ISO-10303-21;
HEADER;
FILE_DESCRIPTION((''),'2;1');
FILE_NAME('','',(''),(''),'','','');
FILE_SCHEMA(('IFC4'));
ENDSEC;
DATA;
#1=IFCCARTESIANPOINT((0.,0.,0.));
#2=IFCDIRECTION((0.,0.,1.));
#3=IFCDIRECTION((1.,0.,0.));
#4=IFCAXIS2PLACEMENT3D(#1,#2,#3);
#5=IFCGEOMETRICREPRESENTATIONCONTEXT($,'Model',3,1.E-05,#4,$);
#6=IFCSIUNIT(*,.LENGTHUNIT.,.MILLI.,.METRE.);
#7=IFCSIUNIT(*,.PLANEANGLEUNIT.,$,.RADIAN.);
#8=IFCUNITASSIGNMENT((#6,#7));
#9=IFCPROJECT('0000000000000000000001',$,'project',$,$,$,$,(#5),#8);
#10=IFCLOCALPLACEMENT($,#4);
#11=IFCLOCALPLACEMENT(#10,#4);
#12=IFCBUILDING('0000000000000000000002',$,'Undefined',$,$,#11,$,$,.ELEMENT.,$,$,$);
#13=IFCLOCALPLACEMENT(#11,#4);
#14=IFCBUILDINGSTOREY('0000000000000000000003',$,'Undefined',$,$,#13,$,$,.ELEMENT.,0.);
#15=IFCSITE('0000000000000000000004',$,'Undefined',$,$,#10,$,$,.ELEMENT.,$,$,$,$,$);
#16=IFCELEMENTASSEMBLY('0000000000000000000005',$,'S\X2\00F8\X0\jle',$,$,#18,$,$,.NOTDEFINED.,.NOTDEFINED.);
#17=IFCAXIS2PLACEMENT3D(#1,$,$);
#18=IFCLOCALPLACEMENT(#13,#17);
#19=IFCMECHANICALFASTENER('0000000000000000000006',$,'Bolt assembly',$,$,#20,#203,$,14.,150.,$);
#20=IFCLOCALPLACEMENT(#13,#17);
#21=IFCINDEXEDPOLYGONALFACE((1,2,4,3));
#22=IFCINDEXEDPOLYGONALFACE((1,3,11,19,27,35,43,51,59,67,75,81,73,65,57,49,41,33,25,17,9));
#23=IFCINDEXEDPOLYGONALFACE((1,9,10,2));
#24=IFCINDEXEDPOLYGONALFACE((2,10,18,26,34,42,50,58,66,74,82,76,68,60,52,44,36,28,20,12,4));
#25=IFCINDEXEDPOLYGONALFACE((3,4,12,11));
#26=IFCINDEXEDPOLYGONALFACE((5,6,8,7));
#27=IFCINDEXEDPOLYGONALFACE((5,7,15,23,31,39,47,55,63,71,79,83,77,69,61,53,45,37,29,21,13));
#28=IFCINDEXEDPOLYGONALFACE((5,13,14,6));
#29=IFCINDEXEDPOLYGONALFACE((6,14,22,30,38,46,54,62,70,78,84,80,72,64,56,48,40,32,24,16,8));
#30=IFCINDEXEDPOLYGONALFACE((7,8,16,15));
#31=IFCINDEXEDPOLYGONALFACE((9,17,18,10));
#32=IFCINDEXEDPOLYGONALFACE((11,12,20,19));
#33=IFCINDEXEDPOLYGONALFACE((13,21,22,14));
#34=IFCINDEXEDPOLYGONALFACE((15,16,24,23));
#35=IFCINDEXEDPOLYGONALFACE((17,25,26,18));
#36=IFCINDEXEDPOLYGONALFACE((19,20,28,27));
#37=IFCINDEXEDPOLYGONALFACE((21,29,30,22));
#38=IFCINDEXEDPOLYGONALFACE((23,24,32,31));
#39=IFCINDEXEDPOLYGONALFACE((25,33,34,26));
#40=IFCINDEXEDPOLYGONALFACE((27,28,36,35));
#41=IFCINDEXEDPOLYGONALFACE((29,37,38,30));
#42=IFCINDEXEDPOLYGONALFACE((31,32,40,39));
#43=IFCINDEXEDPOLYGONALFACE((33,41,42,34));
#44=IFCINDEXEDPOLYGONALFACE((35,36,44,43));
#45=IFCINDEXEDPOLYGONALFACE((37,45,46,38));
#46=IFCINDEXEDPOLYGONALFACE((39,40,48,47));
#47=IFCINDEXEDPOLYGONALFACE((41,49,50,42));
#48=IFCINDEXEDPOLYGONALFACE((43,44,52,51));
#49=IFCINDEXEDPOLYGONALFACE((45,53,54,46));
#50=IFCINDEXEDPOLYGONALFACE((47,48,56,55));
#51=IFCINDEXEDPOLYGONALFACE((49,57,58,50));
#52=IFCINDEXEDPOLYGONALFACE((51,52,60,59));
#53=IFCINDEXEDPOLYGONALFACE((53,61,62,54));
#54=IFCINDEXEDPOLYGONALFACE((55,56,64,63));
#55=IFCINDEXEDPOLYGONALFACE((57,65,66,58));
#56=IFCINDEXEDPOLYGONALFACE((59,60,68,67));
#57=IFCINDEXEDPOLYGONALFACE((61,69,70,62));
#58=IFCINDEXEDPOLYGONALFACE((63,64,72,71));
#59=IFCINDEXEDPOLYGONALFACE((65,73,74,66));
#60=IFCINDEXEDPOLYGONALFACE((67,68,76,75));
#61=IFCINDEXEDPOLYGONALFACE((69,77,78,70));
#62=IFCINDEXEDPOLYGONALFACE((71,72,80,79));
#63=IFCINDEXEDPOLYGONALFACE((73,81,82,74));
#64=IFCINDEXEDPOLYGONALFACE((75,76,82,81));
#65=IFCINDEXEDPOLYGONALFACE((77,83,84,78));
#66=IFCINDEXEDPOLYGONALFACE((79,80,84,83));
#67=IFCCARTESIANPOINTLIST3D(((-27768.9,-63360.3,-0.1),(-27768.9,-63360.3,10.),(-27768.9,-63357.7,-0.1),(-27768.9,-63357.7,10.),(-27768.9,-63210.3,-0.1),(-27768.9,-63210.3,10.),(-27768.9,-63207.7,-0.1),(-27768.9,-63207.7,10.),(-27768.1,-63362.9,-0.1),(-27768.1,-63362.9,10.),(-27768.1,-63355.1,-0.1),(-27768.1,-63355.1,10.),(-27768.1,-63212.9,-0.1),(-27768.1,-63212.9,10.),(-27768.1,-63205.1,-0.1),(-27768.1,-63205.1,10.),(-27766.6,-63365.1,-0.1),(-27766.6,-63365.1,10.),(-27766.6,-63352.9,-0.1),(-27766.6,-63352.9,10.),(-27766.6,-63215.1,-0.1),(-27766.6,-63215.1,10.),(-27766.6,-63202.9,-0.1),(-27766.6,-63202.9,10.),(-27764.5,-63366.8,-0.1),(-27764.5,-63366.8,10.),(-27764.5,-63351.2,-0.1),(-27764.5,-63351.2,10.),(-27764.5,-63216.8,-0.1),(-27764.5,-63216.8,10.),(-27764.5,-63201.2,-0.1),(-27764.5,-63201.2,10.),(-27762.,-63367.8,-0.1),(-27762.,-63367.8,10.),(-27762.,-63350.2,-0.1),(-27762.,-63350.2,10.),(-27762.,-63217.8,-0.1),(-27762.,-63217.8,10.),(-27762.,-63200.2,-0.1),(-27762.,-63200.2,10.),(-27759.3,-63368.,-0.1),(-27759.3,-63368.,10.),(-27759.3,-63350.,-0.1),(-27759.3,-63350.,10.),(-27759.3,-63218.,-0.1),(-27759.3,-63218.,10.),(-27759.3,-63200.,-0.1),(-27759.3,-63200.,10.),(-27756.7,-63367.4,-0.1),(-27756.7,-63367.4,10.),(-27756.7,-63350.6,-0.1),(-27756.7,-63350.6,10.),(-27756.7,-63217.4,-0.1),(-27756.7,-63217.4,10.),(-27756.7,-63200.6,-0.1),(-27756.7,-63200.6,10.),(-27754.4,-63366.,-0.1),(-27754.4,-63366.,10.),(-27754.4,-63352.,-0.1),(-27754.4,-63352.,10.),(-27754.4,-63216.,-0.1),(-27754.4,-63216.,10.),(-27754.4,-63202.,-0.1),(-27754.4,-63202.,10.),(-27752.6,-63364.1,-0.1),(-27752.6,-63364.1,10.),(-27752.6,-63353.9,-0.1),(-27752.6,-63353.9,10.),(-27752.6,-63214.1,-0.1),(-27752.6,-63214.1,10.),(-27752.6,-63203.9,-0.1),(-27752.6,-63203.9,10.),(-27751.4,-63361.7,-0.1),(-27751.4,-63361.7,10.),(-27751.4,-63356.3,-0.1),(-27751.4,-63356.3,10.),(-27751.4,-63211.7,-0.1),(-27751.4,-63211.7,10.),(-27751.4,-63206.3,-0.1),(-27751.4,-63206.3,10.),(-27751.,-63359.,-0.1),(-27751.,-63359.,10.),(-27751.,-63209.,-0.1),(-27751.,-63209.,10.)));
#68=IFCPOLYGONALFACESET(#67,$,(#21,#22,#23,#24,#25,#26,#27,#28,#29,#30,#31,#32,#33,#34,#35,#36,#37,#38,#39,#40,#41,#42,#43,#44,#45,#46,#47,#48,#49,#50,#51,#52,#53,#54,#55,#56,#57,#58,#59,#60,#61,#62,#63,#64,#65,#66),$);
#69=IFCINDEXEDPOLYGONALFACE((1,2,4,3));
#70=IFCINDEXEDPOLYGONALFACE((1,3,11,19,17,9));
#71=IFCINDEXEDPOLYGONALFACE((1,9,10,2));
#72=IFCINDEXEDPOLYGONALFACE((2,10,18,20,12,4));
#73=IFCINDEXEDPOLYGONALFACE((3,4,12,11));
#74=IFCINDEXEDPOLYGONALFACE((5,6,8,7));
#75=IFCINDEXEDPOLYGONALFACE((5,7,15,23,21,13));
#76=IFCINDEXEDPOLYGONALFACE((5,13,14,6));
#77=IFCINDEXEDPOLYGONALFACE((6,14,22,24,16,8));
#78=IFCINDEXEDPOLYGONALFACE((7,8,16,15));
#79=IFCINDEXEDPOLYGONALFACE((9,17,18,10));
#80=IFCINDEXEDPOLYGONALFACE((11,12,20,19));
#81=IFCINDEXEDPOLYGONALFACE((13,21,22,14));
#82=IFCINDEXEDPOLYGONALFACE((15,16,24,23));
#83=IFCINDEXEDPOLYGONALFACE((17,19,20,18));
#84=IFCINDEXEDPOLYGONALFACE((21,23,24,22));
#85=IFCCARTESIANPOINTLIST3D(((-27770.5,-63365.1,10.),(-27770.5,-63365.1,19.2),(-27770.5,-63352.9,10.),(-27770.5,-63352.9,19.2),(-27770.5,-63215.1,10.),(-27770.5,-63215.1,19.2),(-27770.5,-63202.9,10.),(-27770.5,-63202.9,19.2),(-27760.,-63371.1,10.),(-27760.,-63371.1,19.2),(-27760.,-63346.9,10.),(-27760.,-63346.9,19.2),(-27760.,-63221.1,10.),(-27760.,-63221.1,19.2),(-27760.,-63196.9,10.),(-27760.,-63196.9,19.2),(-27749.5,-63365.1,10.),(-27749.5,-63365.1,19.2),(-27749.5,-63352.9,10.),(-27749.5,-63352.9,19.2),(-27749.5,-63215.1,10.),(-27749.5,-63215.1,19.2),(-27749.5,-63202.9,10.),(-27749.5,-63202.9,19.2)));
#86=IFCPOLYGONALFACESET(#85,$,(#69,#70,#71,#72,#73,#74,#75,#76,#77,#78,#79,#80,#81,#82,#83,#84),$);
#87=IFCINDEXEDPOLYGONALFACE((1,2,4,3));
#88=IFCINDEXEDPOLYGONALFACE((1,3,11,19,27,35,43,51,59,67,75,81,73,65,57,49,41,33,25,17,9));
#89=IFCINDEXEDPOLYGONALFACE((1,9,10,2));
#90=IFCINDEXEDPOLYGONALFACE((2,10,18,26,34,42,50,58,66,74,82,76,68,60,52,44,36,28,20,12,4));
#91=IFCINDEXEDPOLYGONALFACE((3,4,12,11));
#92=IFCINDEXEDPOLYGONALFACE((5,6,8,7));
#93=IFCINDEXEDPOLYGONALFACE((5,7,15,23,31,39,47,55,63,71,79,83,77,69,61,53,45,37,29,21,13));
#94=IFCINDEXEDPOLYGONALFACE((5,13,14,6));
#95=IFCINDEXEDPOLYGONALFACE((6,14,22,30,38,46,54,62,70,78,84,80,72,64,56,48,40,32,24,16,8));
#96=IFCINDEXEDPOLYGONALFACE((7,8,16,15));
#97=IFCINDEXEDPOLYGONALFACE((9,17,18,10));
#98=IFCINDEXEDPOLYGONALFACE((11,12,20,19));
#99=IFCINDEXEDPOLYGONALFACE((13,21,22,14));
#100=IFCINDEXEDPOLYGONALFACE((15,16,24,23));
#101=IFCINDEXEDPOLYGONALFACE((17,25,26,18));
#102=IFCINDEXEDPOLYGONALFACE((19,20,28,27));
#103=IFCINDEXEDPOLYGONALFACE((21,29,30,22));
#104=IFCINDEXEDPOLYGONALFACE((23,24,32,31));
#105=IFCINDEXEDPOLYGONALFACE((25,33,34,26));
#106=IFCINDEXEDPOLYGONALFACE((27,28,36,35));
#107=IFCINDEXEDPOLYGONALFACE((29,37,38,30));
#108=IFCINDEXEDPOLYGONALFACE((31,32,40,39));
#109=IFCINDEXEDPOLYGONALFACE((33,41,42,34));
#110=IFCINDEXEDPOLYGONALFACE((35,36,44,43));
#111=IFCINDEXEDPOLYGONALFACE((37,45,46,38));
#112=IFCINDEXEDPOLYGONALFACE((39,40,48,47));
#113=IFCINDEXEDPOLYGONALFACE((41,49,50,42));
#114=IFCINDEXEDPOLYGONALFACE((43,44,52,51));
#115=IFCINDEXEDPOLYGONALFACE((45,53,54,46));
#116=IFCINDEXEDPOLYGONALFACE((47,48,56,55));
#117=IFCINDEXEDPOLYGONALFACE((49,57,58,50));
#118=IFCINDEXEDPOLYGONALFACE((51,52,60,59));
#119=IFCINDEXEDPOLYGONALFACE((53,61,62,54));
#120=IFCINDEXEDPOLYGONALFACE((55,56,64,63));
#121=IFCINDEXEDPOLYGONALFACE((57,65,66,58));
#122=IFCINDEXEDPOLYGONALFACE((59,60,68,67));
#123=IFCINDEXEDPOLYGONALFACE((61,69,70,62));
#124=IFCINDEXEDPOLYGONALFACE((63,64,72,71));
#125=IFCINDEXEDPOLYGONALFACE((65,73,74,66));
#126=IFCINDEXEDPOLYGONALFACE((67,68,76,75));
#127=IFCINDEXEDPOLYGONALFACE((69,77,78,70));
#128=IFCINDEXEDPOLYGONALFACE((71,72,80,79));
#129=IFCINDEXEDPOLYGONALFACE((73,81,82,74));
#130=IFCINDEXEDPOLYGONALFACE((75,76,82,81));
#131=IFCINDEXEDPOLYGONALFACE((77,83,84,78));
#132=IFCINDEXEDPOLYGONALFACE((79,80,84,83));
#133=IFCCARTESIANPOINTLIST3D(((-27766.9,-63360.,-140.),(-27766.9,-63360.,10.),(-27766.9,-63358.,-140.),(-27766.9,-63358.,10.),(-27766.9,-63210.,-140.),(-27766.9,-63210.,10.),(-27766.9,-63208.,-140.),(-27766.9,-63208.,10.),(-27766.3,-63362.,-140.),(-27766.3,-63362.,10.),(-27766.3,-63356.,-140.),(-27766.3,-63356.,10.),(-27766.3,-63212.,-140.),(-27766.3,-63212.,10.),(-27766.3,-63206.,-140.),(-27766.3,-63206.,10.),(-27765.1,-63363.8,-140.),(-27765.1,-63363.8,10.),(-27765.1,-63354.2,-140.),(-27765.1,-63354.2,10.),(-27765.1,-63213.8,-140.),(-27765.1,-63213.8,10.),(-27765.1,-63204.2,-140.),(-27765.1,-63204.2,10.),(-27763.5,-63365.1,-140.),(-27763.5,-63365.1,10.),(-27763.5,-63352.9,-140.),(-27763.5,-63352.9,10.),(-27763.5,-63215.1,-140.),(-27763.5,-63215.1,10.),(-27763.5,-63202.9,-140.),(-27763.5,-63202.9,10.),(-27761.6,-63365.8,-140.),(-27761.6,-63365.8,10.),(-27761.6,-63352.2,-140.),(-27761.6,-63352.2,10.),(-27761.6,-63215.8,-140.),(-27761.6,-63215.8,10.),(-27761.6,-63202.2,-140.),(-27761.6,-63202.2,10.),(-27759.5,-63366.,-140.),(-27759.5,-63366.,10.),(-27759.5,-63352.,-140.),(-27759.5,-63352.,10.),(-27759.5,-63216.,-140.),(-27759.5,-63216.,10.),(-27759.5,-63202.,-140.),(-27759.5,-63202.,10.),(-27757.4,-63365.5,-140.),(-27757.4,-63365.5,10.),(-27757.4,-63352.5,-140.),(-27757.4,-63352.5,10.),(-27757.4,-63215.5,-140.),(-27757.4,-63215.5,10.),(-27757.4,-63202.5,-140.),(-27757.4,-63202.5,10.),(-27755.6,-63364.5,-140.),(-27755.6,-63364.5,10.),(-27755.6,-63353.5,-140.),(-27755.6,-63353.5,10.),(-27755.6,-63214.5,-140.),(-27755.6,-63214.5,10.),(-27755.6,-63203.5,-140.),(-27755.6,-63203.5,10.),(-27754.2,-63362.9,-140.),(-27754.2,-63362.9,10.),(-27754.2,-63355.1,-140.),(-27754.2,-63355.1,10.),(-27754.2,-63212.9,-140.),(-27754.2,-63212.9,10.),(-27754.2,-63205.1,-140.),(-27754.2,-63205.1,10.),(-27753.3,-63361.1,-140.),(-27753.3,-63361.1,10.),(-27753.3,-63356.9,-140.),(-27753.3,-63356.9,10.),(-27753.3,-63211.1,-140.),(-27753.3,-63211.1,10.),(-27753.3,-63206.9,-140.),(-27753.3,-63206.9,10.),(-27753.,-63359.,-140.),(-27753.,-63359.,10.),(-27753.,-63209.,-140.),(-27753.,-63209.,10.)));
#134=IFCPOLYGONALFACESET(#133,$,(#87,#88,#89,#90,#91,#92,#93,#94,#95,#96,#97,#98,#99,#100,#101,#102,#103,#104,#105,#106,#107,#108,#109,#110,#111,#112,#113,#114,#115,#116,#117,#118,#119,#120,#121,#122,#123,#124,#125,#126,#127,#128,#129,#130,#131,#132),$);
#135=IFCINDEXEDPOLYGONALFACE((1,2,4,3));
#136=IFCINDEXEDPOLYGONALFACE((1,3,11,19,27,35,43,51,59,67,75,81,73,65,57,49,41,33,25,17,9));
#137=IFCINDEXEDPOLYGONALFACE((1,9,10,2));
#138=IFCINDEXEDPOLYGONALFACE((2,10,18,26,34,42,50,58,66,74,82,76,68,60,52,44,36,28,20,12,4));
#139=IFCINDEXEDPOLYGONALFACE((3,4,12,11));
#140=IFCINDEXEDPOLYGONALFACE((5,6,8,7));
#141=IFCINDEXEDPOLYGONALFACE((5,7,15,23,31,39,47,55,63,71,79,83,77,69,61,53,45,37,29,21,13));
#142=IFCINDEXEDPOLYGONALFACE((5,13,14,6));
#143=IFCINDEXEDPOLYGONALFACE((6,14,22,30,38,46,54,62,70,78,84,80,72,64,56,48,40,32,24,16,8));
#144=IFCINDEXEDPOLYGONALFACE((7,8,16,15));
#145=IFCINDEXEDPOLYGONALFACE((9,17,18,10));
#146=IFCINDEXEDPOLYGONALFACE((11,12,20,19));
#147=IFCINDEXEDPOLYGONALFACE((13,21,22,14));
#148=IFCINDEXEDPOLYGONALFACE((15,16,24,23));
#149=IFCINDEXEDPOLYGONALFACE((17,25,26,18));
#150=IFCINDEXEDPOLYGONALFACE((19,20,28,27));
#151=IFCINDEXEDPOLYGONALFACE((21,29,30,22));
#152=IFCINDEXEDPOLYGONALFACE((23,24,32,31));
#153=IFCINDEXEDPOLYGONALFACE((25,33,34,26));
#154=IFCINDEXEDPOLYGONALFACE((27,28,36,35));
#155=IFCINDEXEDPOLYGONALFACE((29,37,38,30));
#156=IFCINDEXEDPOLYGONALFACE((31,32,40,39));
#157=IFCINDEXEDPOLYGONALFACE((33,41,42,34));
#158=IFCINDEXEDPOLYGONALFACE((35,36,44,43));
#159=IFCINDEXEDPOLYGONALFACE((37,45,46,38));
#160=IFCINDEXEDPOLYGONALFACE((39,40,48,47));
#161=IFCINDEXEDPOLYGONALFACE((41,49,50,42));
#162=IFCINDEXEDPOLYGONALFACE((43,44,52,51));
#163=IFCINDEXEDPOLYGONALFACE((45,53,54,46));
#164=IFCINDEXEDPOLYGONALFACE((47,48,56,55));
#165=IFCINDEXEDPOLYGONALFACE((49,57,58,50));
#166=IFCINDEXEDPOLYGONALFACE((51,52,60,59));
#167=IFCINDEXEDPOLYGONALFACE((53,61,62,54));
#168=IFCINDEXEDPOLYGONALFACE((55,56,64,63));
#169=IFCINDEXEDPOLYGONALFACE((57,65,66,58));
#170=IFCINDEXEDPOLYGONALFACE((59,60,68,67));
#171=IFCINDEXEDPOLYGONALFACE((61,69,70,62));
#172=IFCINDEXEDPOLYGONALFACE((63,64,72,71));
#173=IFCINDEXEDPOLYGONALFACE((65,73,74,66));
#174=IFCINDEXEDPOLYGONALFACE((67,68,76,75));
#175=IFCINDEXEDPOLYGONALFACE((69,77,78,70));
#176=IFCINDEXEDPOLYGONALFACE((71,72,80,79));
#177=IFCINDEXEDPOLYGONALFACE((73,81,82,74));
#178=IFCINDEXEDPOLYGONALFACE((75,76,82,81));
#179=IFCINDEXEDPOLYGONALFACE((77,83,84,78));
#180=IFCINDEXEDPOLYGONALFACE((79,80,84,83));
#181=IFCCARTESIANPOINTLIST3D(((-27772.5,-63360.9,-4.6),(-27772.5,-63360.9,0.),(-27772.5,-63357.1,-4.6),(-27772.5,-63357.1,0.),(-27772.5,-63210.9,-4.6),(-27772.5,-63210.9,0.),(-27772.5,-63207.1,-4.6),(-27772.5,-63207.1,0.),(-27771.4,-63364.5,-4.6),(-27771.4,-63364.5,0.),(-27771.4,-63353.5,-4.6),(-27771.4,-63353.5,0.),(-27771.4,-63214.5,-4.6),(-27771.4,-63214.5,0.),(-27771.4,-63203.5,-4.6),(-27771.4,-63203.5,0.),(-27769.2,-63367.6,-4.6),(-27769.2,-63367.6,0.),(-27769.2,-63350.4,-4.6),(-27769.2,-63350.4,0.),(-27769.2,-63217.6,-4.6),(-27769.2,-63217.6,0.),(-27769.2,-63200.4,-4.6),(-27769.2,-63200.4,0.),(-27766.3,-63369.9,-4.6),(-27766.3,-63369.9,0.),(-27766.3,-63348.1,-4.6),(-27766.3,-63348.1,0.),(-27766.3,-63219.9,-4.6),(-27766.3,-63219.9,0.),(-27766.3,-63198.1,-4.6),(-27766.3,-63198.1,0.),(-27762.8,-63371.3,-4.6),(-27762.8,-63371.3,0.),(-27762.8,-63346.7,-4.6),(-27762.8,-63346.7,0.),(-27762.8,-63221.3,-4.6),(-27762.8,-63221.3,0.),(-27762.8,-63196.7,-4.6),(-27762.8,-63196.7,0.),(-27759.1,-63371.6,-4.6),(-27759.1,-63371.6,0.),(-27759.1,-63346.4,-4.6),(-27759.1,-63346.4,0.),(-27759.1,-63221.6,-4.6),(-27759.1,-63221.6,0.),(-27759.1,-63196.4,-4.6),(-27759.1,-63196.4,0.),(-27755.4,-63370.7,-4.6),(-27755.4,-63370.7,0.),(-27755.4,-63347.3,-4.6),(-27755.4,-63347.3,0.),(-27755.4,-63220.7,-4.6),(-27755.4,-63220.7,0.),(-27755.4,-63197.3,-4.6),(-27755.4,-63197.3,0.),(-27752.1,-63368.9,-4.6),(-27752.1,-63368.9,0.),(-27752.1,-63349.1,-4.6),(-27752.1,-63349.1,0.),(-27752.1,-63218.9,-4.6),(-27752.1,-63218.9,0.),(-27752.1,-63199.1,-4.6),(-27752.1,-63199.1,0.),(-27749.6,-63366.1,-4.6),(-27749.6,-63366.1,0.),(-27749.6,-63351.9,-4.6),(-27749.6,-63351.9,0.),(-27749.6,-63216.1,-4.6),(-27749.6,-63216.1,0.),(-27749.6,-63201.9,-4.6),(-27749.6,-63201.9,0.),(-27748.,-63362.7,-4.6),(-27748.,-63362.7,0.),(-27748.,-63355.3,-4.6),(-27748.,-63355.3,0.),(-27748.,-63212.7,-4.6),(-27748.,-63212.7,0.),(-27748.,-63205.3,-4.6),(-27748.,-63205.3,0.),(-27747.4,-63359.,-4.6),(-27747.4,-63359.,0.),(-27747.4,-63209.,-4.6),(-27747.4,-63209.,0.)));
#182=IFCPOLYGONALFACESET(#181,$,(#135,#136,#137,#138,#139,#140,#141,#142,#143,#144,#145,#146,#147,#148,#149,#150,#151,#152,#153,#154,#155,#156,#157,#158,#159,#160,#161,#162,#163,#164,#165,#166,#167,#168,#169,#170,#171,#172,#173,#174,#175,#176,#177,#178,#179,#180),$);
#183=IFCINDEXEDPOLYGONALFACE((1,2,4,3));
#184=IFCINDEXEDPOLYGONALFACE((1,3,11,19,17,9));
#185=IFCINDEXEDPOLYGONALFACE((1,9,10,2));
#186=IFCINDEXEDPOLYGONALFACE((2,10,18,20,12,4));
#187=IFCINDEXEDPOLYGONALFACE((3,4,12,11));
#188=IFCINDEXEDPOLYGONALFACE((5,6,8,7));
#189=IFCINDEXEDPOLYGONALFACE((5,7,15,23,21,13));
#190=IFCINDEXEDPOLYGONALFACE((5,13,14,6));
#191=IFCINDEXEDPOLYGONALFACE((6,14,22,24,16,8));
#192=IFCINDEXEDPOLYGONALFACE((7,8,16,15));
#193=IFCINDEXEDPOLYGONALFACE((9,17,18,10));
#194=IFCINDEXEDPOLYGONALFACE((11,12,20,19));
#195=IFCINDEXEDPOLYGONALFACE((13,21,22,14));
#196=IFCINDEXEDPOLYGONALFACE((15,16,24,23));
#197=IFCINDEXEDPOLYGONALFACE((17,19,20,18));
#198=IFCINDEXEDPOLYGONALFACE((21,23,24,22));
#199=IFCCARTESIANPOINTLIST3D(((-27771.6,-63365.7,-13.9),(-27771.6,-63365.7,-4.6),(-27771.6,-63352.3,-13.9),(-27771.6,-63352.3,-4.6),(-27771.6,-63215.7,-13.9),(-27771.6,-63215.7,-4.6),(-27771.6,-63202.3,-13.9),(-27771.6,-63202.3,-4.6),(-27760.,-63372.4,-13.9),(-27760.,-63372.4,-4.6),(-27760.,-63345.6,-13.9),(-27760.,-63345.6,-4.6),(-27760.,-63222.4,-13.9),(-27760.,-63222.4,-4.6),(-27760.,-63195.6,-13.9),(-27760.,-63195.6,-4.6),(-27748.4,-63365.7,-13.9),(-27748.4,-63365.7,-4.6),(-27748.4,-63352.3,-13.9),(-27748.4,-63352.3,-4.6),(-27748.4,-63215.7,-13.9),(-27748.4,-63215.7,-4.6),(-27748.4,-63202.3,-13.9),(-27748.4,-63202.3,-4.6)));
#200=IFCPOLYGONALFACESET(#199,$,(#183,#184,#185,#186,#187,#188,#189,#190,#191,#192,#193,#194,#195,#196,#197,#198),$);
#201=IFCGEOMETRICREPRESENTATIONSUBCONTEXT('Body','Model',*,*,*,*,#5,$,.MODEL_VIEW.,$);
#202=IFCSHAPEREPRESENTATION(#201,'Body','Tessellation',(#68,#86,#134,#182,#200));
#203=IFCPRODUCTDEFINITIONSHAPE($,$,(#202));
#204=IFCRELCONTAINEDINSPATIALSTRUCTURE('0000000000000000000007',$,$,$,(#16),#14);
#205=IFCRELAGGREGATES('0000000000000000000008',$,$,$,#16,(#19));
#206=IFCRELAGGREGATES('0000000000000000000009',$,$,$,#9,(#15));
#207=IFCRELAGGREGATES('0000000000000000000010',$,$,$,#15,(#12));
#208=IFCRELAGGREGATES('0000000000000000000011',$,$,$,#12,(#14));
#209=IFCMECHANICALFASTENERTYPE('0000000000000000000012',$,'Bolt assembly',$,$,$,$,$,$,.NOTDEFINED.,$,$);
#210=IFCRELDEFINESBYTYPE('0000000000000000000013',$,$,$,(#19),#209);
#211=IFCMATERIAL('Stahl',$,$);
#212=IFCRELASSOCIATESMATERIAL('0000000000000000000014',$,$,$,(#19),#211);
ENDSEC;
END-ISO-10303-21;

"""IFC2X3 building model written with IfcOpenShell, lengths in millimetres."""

from ifc_helpers import new_model, si_unit, frame, origin_with_axes, origin_2d_with_axis, place, context, subcontext, project, spatial, polyline, circle, outline, extrude, source, transform, mapped, material, type_object, element, aggregate, save


model = new_model("IFC2X3")

# Units and contexts
model_context = context("Model", 3, precision=1e-05, world=origin_with_axes())
body_context = subcontext(model_context, "Body", "Model", "MODEL_VIEW")
ifc_project = project(units=[si_unit("LENGTHUNIT", "METRE", prefix="MILLI"), si_unit("PLANEANGLEUNIT", "RADIAN")], contexts=[model_context])

# Site, building, storey
site_placement = place(None, origin_with_axes())
site = spatial("IfcSite", under=ifc_project, at=site_placement, Name="Undefined", CompositionType="ELEMENT")
building_placement = place(site_placement, origin_with_axes())
building = spatial("IfcBuilding", under=site, at=building_placement, Name="Undefined", CompositionType="ELEMENT")
storey_placement = place(building_placement, origin_with_axes())
storey = spatial("IfcBuildingStorey", under=building, at=storey_placement, Name="Undefined", CompositionType="ELEMENT", Elevation=0.0)

# Shared definitions
mechanical_fastener_type = type_object("IfcMechanicalFastenerType", Name="Bolt assembly")

# Element assembly
assembly_1_placement = place(storey_placement, origin_with_axes())
assembly_1 = element("IfcElementAssembly", 1, at=assembly_1_placement, inside=storey, Name="Søjle", AssemblyPlace="NOTDEFINED", PredefinedType="NOTDEFINED")

# Mechanical fastener
ifc_material_1 = material(Name="Stahl")
shared_shape_1 = source(origin_with_axes(), body_context, "Body", "SweptSolid", [
    extrude(circle(Radius=9.0, at=origin_2d_with_axis()), frame((0.0, 0.0, 0.0), z_axis=(0.0, 1.0, 0.0), x_axis=(1.0, 0.0, 0.0)), (0.0, 0.0, 1.0), 10.1),
    extrude(outline(polyline([(10.5, -6.1), (10.5, 6.1), (0.0, 12.1), (-10.5, 6.1), (-10.5, -6.1), (0.0, -12.1), (10.5, -6.1)])), frame((0.0, -9.2, 0.0), z_axis=(0.0, 1.0, 0.0), x_axis=(1.0, 0.0, 0.0)), (0.0, 0.0, 1.0), 9.2),
    extrude(circle(Radius=7.0, at=origin_2d_with_axis()), frame((0.0, 0.0, 0.0), z_axis=(0.0, 1.0, 0.0), x_axis=(1.0, 0.0, 0.0)), (0.0, 0.0, 1.0), 150.0),
    extrude(circle(Radius=12.6, at=origin_2d_with_axis()), frame((0.0, 10.0, 0.0), z_axis=(0.0, 1.0, 0.0), x_axis=(1.0, 0.0, 0.0)), (0.0, 0.0, 1.0), 4.6),
    extrude(outline(polyline([(11.6, -6.7), (11.6, 6.7), (0.0, 13.4), (-11.6, 6.7), (-11.6, -6.7), (0.0, -13.4), (11.6, -6.7)])), frame((0.0, 14.6, 0.0), z_axis=(0.0, 1.0, 0.0), x_axis=(1.0, 0.0, 0.0)), (0.0, 0.0, 1.0), 9.2),
])
mechanical_fastener_1_placement = place(assembly_1_placement, frame((-27760.0, -63284.0, 10.0), z_axis=(0.0, 1.0, 0.0), x_axis=(1.0, 0.0, 0.0)))
mechanical_fastener_1 = element("IfcMechanicalFastener", 2, at=mechanical_fastener_1_placement, type_object=mechanical_fastener_type, material=ifc_material_1, Name="Bolt assembly", NominalDiameter=14.0, NominalLength=150.0, context=body_context, shape_type="MappedRepresentation", body=[
    mapped(shared_shape_1, transform((0.0, 0.0, -75.0))),
    mapped(shared_shape_1, transform((0.0, 0.0, 75.0))),
])
aggregate(assembly_1, [mechanical_fastener_1])

save(model, "model.ifc")
